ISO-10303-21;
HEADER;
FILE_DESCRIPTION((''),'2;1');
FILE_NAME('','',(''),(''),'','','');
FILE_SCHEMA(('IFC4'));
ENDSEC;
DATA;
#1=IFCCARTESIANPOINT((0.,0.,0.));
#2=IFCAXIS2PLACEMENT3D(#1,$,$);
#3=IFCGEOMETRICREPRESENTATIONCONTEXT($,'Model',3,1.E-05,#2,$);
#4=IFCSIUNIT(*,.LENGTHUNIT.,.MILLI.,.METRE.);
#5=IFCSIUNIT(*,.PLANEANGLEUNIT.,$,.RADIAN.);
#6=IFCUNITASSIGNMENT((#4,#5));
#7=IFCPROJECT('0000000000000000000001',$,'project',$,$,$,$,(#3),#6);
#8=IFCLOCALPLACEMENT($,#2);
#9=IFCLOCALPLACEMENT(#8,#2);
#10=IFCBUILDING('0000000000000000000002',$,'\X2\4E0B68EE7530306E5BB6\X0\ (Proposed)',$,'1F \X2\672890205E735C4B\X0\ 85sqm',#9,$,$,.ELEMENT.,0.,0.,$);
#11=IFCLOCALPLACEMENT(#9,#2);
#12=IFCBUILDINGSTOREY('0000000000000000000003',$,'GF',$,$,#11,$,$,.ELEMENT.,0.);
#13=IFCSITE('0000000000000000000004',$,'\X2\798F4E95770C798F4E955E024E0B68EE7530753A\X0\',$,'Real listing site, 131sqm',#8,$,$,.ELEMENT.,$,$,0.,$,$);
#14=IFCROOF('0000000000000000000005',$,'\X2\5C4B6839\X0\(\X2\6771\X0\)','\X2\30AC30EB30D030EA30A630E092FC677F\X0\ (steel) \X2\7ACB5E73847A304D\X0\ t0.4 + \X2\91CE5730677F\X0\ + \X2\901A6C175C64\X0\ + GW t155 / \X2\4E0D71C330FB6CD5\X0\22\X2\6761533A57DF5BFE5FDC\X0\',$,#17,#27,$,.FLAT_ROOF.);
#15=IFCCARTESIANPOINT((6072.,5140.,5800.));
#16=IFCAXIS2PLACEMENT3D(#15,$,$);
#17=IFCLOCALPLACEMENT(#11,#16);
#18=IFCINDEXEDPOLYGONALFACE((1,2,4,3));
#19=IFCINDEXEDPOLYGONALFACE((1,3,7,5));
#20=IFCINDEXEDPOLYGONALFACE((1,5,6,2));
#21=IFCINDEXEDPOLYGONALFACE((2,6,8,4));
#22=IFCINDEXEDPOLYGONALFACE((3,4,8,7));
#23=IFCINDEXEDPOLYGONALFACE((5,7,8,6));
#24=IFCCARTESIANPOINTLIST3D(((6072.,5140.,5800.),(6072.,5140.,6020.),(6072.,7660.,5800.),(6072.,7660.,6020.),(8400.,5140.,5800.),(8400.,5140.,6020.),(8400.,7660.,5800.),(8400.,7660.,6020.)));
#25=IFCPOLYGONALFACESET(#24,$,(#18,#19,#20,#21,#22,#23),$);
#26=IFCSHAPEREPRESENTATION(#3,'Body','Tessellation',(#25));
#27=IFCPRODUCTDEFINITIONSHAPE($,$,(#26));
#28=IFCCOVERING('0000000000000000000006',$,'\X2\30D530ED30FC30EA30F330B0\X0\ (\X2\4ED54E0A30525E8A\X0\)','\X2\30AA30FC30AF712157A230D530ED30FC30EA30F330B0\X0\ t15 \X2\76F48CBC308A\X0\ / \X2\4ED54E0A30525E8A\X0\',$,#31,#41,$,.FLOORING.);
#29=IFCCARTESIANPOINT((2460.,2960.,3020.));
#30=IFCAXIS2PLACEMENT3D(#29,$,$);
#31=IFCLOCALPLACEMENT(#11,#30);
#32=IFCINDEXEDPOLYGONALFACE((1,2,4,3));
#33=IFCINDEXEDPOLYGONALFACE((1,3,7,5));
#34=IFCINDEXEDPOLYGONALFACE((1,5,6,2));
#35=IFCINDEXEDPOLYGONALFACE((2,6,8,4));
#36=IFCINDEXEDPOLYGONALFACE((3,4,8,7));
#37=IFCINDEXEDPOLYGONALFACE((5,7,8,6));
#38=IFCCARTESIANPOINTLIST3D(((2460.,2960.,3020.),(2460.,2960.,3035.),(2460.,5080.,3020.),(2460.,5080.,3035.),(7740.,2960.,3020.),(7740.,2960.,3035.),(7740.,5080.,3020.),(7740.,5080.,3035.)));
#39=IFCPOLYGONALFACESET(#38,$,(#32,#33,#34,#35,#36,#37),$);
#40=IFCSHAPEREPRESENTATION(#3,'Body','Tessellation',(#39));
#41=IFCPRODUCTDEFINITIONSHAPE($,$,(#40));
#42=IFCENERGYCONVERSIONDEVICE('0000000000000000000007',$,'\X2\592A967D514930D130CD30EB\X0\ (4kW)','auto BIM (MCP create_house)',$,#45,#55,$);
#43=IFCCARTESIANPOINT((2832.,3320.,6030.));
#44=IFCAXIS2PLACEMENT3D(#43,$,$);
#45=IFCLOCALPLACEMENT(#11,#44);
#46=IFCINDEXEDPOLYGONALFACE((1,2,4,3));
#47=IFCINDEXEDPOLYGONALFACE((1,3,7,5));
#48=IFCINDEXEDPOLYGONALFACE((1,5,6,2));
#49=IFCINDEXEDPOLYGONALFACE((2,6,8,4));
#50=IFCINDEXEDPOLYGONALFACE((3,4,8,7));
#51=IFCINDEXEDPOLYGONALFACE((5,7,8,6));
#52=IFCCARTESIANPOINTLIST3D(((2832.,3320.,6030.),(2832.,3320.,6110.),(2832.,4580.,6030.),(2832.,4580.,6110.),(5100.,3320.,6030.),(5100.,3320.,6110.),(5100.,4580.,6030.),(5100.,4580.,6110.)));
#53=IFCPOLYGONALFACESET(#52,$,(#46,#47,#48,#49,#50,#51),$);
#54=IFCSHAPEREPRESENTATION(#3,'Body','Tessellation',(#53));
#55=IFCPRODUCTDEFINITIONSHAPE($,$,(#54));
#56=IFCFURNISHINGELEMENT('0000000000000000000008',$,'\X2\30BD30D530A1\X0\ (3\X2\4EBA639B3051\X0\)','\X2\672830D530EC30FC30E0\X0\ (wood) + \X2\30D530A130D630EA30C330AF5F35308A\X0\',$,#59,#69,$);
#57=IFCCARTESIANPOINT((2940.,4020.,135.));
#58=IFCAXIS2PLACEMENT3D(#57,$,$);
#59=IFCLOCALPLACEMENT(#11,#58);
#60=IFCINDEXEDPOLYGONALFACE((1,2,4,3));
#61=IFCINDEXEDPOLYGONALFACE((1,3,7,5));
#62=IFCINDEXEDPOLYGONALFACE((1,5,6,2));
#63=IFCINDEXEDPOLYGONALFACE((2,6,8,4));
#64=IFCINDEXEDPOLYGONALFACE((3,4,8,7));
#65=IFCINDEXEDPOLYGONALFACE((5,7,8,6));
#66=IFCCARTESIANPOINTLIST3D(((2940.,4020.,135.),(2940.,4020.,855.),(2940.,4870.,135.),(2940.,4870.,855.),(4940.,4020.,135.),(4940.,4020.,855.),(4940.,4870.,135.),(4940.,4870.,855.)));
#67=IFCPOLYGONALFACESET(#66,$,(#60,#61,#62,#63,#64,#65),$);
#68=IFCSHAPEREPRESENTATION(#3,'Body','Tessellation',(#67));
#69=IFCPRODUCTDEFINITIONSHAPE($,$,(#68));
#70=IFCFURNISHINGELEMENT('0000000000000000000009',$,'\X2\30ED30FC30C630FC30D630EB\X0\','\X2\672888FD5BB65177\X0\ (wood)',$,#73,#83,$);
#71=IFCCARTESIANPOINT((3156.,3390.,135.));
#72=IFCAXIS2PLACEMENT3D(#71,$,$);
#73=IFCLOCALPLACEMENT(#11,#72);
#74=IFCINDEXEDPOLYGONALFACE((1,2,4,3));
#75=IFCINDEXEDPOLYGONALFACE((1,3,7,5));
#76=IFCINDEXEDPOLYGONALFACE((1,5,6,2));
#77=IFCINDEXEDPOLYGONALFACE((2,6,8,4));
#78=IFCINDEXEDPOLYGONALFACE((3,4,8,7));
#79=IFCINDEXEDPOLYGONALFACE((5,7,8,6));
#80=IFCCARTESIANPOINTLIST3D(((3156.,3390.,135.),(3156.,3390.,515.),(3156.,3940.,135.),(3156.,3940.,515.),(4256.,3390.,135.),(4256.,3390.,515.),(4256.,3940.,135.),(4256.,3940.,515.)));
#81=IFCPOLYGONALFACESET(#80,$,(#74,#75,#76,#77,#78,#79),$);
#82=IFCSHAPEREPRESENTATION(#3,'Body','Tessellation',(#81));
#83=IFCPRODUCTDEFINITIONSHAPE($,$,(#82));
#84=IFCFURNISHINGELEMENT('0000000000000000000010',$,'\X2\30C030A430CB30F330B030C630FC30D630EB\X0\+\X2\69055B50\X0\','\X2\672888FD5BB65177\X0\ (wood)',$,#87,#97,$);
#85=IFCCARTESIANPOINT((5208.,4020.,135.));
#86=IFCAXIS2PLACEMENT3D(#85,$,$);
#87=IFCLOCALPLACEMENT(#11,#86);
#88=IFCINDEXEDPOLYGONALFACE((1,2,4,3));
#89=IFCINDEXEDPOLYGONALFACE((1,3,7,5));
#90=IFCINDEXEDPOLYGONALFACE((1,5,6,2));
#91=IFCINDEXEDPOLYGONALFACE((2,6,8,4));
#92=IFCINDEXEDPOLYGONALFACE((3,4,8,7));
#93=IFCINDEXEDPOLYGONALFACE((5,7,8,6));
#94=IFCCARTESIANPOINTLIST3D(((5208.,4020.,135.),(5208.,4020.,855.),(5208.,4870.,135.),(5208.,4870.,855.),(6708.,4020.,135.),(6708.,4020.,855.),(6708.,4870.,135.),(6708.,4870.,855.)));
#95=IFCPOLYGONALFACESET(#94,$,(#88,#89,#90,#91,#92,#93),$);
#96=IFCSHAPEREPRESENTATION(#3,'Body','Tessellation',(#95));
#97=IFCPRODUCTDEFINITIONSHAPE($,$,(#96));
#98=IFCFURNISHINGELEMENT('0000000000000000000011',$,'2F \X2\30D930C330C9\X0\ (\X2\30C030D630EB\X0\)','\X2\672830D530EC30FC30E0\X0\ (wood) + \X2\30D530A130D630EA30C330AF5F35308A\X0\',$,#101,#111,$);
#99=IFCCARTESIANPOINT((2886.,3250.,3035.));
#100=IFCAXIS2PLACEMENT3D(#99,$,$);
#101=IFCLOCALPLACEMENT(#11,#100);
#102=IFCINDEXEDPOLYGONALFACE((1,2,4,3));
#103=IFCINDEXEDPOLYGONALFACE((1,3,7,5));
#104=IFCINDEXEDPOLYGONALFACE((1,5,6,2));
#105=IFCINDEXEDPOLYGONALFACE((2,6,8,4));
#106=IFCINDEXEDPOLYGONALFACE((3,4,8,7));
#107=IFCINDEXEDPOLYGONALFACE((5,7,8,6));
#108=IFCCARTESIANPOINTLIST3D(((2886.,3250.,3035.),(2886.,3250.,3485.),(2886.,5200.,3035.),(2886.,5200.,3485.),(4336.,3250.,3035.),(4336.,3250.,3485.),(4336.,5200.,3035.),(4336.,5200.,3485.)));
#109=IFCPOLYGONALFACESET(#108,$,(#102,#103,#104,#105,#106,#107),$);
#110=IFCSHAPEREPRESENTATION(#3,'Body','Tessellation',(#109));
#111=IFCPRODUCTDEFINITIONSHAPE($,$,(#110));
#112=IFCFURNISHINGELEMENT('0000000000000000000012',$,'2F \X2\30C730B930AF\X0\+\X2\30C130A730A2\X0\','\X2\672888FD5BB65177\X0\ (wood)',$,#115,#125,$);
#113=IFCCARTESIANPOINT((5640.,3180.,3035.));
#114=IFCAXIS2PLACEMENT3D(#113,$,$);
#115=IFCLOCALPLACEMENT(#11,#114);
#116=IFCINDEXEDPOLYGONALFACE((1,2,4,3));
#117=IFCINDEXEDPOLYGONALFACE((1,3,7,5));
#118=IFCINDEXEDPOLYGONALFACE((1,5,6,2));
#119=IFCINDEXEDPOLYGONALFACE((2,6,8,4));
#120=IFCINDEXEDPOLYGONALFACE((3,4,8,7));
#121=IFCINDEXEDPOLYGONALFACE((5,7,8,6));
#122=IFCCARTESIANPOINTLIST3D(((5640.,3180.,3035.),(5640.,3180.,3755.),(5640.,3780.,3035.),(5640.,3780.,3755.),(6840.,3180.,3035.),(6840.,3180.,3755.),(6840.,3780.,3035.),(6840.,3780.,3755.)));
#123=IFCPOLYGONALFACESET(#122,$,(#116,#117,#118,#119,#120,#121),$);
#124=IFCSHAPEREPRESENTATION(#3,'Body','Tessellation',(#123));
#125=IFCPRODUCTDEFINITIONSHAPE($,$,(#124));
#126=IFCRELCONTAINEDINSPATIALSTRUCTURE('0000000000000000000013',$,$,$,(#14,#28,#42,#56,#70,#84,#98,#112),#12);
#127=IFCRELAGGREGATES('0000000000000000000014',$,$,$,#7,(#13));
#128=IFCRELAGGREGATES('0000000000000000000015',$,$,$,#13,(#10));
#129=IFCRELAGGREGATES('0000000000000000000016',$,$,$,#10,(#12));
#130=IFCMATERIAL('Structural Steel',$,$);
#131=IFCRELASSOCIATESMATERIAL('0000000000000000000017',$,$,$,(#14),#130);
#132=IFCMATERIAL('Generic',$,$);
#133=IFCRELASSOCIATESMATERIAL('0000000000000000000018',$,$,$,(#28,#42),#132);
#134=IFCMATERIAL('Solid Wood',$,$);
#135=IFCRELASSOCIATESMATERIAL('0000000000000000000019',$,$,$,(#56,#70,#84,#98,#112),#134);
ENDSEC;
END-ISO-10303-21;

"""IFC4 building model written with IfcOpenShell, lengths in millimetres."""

from ifc_helpers import new_model, si_unit, frame, frame_2d, origin, place, context, project, spatial, rectangle, extrude, material, element, save


model = new_model("IFC4")

# Units and contexts
model_context = context("Model", 3, precision=1e-05, world=origin())
ifc_project = project(units=[si_unit("LENGTHUNIT", "METRE", prefix="MILLI"), si_unit("PLANEANGLEUNIT", "RADIAN")], contexts=[model_context])

# Site, building, storey
site_placement = place(None, origin())
site = spatial("IfcSite", under=ifc_project, at=site_placement, Name="福井県福井市下森田町", ObjectType="Real listing site, 131sqm", CompositionType="ELEMENT", RefElevation=0.0)
building_placement = place(site_placement, origin())
building = spatial("IfcBuilding", under=site, at=building_placement, Name="下森田の家 (Proposed)", ObjectType="1F 木造平屋 85sqm", CompositionType="ELEMENT", ElevationOfRefHeight=0.0, ElevationOfTerrain=0.0)
storey_placement = place(building_placement, origin())
storey = spatial("IfcBuildingStorey", under=building, at=storey_placement, Name="GF", CompositionType="ELEMENT", Elevation=0.0)

# Shared definitions
ifc_material_1 = material(Name="Solid Wood")

# Roof
ifc_material_2 = material(Name="Structural Steel")
roof_1_placement = place(storey_placement, frame((6072.0, 5140.0, 5800.0)))
element("IfcRoof", 1, at=roof_1_placement, inside=storey, material=ifc_material_2, Name="屋根(東)", Description="ガルバリウム鋼板 (steel) 立平葺き t0.4 + 野地板 + 通気層 + GW t155 / 不燃・法22条区域対応", PredefinedType="FLAT_ROOF", context=model_context, shape_type="SweptSolid", body=[
    extrude(rectangle(XDim=2328.0, YDim=2520.0, at=frame_2d((1164.0, 1260.0))), frame((6072.0, 5140.0, 5800.0)), (0.0, 0.0, 1.0), 220.0),
])

# Covering
ifc_material_3 = material(Name="Generic")
covering_placement = place(storey_placement, frame((2460.0, 2960.0, 3020.0)))
element("IfcCovering", 2, at=covering_placement, inside=storey, material=ifc_material_3, Name="フローリング (仕上げ床)", Description="オーク無垢フローリング t15 直貼り / 仕上げ床", PredefinedType="FLOORING", context=model_context, shape_type="SweptSolid", body=[
    extrude(rectangle(XDim=5280.0, YDim=2120.0, at=frame_2d((2640.0, 1060.0))), frame((2460.0, 2960.0, 3020.0)), (0.0, 0.0, 1.0), 15.0),
])

# Energy conversion device
energy_conversion_device_placement = place(storey_placement, frame((2832.0, 3320.0, 6030.0)))
element("IfcEnergyConversionDevice", 3, at=energy_conversion_device_placement, inside=storey, material=ifc_material_3, Name="太陽光パネル (4kW)", Description="auto BIM (MCP create_house)", context=model_context, shape_type="SweptSolid", body=[
    extrude(rectangle(XDim=2268.0, YDim=1260.0, at=frame_2d((1134.0, 630.0))), frame((2832.0, 3320.0, 6030.0)), (0.0, 0.0, 1.0), 80.0),
])

# Furnishing elements
furnishing_1_placement = place(storey_placement, frame((2940.0, 4020.0, 135.0)))
element("IfcFurnishingElement", 4, at=furnishing_1_placement, inside=storey, material=ifc_material_1, Name="ソファ (3人掛け)", Description="木フレーム (wood) + ファブリック張り", context=model_context, shape_type="SweptSolid", body=[
    extrude(rectangle(XDim=2000.0, YDim=850.0, at=frame_2d((1000.0, 425.0))), frame((2940.0, 4020.0, 135.0)), (0.0, 0.0, 1.0), 720.0),
])
furnishing_2_placement = place(storey_placement, frame((3156.0, 3390.0, 135.0)))
element("IfcFurnishingElement", 5, at=furnishing_2_placement, inside=storey, material=ifc_material_1, Name="ローテーブル", Description="木製家具 (wood)", context=model_context, shape_type="SweptSolid", body=[
    extrude(rectangle(XDim=1100.0, YDim=550.0, at=frame_2d((550.0, 275.0))), frame((3156.0, 3390.0, 135.0)), (0.0, 0.0, 1.0), 380.0),
])
furnishing_3_placement = place(storey_placement, frame((5208.0, 4020.0, 135.0)))
element("IfcFurnishingElement", 6, at=furnishing_3_placement, inside=storey, material=ifc_material_1, Name="ダイニングテーブル+椅子", Description="木製家具 (wood)", context=model_context, shape_type="SweptSolid", body=[
    extrude(rectangle(XDim=1500.0, YDim=850.0, at=frame_2d((750.0, 425.0))), frame((5208.0, 4020.0, 135.0)), (0.0, 0.0, 1.0), 720.0),
])
furnishing_4_placement = place(storey_placement, frame((2886.0, 3250.0, 3035.0)))
element("IfcFurnishingElement", 7, at=furnishing_4_placement, inside=storey, material=ifc_material_1, Name="2F ベッド (ダブル)", Description="木フレーム (wood) + ファブリック張り", context=model_context, shape_type="SweptSolid", body=[
    extrude(rectangle(XDim=1450.0, YDim=1950.0, at=frame_2d((725.0, 975.0))), frame((2886.0, 3250.0, 3035.0)), (0.0, 0.0, 1.0), 450.0),
])
furnishing_5_placement = place(storey_placement, frame((5640.0, 3180.0, 3035.0)))
element("IfcFurnishingElement", 8, at=furnishing_5_placement, inside=storey, material=ifc_material_1, Name="2F デスク+チェア", Description="木製家具 (wood)", context=model_context, shape_type="SweptSolid", body=[
    extrude(rectangle(XDim=1200.0, YDim=600.0, at=frame_2d((600.0, 300.0))), frame((5640.0, 3180.0, 3035.0)), (0.0, 0.0, 1.0), 720.0),
])

save(model, "model.ifc")
